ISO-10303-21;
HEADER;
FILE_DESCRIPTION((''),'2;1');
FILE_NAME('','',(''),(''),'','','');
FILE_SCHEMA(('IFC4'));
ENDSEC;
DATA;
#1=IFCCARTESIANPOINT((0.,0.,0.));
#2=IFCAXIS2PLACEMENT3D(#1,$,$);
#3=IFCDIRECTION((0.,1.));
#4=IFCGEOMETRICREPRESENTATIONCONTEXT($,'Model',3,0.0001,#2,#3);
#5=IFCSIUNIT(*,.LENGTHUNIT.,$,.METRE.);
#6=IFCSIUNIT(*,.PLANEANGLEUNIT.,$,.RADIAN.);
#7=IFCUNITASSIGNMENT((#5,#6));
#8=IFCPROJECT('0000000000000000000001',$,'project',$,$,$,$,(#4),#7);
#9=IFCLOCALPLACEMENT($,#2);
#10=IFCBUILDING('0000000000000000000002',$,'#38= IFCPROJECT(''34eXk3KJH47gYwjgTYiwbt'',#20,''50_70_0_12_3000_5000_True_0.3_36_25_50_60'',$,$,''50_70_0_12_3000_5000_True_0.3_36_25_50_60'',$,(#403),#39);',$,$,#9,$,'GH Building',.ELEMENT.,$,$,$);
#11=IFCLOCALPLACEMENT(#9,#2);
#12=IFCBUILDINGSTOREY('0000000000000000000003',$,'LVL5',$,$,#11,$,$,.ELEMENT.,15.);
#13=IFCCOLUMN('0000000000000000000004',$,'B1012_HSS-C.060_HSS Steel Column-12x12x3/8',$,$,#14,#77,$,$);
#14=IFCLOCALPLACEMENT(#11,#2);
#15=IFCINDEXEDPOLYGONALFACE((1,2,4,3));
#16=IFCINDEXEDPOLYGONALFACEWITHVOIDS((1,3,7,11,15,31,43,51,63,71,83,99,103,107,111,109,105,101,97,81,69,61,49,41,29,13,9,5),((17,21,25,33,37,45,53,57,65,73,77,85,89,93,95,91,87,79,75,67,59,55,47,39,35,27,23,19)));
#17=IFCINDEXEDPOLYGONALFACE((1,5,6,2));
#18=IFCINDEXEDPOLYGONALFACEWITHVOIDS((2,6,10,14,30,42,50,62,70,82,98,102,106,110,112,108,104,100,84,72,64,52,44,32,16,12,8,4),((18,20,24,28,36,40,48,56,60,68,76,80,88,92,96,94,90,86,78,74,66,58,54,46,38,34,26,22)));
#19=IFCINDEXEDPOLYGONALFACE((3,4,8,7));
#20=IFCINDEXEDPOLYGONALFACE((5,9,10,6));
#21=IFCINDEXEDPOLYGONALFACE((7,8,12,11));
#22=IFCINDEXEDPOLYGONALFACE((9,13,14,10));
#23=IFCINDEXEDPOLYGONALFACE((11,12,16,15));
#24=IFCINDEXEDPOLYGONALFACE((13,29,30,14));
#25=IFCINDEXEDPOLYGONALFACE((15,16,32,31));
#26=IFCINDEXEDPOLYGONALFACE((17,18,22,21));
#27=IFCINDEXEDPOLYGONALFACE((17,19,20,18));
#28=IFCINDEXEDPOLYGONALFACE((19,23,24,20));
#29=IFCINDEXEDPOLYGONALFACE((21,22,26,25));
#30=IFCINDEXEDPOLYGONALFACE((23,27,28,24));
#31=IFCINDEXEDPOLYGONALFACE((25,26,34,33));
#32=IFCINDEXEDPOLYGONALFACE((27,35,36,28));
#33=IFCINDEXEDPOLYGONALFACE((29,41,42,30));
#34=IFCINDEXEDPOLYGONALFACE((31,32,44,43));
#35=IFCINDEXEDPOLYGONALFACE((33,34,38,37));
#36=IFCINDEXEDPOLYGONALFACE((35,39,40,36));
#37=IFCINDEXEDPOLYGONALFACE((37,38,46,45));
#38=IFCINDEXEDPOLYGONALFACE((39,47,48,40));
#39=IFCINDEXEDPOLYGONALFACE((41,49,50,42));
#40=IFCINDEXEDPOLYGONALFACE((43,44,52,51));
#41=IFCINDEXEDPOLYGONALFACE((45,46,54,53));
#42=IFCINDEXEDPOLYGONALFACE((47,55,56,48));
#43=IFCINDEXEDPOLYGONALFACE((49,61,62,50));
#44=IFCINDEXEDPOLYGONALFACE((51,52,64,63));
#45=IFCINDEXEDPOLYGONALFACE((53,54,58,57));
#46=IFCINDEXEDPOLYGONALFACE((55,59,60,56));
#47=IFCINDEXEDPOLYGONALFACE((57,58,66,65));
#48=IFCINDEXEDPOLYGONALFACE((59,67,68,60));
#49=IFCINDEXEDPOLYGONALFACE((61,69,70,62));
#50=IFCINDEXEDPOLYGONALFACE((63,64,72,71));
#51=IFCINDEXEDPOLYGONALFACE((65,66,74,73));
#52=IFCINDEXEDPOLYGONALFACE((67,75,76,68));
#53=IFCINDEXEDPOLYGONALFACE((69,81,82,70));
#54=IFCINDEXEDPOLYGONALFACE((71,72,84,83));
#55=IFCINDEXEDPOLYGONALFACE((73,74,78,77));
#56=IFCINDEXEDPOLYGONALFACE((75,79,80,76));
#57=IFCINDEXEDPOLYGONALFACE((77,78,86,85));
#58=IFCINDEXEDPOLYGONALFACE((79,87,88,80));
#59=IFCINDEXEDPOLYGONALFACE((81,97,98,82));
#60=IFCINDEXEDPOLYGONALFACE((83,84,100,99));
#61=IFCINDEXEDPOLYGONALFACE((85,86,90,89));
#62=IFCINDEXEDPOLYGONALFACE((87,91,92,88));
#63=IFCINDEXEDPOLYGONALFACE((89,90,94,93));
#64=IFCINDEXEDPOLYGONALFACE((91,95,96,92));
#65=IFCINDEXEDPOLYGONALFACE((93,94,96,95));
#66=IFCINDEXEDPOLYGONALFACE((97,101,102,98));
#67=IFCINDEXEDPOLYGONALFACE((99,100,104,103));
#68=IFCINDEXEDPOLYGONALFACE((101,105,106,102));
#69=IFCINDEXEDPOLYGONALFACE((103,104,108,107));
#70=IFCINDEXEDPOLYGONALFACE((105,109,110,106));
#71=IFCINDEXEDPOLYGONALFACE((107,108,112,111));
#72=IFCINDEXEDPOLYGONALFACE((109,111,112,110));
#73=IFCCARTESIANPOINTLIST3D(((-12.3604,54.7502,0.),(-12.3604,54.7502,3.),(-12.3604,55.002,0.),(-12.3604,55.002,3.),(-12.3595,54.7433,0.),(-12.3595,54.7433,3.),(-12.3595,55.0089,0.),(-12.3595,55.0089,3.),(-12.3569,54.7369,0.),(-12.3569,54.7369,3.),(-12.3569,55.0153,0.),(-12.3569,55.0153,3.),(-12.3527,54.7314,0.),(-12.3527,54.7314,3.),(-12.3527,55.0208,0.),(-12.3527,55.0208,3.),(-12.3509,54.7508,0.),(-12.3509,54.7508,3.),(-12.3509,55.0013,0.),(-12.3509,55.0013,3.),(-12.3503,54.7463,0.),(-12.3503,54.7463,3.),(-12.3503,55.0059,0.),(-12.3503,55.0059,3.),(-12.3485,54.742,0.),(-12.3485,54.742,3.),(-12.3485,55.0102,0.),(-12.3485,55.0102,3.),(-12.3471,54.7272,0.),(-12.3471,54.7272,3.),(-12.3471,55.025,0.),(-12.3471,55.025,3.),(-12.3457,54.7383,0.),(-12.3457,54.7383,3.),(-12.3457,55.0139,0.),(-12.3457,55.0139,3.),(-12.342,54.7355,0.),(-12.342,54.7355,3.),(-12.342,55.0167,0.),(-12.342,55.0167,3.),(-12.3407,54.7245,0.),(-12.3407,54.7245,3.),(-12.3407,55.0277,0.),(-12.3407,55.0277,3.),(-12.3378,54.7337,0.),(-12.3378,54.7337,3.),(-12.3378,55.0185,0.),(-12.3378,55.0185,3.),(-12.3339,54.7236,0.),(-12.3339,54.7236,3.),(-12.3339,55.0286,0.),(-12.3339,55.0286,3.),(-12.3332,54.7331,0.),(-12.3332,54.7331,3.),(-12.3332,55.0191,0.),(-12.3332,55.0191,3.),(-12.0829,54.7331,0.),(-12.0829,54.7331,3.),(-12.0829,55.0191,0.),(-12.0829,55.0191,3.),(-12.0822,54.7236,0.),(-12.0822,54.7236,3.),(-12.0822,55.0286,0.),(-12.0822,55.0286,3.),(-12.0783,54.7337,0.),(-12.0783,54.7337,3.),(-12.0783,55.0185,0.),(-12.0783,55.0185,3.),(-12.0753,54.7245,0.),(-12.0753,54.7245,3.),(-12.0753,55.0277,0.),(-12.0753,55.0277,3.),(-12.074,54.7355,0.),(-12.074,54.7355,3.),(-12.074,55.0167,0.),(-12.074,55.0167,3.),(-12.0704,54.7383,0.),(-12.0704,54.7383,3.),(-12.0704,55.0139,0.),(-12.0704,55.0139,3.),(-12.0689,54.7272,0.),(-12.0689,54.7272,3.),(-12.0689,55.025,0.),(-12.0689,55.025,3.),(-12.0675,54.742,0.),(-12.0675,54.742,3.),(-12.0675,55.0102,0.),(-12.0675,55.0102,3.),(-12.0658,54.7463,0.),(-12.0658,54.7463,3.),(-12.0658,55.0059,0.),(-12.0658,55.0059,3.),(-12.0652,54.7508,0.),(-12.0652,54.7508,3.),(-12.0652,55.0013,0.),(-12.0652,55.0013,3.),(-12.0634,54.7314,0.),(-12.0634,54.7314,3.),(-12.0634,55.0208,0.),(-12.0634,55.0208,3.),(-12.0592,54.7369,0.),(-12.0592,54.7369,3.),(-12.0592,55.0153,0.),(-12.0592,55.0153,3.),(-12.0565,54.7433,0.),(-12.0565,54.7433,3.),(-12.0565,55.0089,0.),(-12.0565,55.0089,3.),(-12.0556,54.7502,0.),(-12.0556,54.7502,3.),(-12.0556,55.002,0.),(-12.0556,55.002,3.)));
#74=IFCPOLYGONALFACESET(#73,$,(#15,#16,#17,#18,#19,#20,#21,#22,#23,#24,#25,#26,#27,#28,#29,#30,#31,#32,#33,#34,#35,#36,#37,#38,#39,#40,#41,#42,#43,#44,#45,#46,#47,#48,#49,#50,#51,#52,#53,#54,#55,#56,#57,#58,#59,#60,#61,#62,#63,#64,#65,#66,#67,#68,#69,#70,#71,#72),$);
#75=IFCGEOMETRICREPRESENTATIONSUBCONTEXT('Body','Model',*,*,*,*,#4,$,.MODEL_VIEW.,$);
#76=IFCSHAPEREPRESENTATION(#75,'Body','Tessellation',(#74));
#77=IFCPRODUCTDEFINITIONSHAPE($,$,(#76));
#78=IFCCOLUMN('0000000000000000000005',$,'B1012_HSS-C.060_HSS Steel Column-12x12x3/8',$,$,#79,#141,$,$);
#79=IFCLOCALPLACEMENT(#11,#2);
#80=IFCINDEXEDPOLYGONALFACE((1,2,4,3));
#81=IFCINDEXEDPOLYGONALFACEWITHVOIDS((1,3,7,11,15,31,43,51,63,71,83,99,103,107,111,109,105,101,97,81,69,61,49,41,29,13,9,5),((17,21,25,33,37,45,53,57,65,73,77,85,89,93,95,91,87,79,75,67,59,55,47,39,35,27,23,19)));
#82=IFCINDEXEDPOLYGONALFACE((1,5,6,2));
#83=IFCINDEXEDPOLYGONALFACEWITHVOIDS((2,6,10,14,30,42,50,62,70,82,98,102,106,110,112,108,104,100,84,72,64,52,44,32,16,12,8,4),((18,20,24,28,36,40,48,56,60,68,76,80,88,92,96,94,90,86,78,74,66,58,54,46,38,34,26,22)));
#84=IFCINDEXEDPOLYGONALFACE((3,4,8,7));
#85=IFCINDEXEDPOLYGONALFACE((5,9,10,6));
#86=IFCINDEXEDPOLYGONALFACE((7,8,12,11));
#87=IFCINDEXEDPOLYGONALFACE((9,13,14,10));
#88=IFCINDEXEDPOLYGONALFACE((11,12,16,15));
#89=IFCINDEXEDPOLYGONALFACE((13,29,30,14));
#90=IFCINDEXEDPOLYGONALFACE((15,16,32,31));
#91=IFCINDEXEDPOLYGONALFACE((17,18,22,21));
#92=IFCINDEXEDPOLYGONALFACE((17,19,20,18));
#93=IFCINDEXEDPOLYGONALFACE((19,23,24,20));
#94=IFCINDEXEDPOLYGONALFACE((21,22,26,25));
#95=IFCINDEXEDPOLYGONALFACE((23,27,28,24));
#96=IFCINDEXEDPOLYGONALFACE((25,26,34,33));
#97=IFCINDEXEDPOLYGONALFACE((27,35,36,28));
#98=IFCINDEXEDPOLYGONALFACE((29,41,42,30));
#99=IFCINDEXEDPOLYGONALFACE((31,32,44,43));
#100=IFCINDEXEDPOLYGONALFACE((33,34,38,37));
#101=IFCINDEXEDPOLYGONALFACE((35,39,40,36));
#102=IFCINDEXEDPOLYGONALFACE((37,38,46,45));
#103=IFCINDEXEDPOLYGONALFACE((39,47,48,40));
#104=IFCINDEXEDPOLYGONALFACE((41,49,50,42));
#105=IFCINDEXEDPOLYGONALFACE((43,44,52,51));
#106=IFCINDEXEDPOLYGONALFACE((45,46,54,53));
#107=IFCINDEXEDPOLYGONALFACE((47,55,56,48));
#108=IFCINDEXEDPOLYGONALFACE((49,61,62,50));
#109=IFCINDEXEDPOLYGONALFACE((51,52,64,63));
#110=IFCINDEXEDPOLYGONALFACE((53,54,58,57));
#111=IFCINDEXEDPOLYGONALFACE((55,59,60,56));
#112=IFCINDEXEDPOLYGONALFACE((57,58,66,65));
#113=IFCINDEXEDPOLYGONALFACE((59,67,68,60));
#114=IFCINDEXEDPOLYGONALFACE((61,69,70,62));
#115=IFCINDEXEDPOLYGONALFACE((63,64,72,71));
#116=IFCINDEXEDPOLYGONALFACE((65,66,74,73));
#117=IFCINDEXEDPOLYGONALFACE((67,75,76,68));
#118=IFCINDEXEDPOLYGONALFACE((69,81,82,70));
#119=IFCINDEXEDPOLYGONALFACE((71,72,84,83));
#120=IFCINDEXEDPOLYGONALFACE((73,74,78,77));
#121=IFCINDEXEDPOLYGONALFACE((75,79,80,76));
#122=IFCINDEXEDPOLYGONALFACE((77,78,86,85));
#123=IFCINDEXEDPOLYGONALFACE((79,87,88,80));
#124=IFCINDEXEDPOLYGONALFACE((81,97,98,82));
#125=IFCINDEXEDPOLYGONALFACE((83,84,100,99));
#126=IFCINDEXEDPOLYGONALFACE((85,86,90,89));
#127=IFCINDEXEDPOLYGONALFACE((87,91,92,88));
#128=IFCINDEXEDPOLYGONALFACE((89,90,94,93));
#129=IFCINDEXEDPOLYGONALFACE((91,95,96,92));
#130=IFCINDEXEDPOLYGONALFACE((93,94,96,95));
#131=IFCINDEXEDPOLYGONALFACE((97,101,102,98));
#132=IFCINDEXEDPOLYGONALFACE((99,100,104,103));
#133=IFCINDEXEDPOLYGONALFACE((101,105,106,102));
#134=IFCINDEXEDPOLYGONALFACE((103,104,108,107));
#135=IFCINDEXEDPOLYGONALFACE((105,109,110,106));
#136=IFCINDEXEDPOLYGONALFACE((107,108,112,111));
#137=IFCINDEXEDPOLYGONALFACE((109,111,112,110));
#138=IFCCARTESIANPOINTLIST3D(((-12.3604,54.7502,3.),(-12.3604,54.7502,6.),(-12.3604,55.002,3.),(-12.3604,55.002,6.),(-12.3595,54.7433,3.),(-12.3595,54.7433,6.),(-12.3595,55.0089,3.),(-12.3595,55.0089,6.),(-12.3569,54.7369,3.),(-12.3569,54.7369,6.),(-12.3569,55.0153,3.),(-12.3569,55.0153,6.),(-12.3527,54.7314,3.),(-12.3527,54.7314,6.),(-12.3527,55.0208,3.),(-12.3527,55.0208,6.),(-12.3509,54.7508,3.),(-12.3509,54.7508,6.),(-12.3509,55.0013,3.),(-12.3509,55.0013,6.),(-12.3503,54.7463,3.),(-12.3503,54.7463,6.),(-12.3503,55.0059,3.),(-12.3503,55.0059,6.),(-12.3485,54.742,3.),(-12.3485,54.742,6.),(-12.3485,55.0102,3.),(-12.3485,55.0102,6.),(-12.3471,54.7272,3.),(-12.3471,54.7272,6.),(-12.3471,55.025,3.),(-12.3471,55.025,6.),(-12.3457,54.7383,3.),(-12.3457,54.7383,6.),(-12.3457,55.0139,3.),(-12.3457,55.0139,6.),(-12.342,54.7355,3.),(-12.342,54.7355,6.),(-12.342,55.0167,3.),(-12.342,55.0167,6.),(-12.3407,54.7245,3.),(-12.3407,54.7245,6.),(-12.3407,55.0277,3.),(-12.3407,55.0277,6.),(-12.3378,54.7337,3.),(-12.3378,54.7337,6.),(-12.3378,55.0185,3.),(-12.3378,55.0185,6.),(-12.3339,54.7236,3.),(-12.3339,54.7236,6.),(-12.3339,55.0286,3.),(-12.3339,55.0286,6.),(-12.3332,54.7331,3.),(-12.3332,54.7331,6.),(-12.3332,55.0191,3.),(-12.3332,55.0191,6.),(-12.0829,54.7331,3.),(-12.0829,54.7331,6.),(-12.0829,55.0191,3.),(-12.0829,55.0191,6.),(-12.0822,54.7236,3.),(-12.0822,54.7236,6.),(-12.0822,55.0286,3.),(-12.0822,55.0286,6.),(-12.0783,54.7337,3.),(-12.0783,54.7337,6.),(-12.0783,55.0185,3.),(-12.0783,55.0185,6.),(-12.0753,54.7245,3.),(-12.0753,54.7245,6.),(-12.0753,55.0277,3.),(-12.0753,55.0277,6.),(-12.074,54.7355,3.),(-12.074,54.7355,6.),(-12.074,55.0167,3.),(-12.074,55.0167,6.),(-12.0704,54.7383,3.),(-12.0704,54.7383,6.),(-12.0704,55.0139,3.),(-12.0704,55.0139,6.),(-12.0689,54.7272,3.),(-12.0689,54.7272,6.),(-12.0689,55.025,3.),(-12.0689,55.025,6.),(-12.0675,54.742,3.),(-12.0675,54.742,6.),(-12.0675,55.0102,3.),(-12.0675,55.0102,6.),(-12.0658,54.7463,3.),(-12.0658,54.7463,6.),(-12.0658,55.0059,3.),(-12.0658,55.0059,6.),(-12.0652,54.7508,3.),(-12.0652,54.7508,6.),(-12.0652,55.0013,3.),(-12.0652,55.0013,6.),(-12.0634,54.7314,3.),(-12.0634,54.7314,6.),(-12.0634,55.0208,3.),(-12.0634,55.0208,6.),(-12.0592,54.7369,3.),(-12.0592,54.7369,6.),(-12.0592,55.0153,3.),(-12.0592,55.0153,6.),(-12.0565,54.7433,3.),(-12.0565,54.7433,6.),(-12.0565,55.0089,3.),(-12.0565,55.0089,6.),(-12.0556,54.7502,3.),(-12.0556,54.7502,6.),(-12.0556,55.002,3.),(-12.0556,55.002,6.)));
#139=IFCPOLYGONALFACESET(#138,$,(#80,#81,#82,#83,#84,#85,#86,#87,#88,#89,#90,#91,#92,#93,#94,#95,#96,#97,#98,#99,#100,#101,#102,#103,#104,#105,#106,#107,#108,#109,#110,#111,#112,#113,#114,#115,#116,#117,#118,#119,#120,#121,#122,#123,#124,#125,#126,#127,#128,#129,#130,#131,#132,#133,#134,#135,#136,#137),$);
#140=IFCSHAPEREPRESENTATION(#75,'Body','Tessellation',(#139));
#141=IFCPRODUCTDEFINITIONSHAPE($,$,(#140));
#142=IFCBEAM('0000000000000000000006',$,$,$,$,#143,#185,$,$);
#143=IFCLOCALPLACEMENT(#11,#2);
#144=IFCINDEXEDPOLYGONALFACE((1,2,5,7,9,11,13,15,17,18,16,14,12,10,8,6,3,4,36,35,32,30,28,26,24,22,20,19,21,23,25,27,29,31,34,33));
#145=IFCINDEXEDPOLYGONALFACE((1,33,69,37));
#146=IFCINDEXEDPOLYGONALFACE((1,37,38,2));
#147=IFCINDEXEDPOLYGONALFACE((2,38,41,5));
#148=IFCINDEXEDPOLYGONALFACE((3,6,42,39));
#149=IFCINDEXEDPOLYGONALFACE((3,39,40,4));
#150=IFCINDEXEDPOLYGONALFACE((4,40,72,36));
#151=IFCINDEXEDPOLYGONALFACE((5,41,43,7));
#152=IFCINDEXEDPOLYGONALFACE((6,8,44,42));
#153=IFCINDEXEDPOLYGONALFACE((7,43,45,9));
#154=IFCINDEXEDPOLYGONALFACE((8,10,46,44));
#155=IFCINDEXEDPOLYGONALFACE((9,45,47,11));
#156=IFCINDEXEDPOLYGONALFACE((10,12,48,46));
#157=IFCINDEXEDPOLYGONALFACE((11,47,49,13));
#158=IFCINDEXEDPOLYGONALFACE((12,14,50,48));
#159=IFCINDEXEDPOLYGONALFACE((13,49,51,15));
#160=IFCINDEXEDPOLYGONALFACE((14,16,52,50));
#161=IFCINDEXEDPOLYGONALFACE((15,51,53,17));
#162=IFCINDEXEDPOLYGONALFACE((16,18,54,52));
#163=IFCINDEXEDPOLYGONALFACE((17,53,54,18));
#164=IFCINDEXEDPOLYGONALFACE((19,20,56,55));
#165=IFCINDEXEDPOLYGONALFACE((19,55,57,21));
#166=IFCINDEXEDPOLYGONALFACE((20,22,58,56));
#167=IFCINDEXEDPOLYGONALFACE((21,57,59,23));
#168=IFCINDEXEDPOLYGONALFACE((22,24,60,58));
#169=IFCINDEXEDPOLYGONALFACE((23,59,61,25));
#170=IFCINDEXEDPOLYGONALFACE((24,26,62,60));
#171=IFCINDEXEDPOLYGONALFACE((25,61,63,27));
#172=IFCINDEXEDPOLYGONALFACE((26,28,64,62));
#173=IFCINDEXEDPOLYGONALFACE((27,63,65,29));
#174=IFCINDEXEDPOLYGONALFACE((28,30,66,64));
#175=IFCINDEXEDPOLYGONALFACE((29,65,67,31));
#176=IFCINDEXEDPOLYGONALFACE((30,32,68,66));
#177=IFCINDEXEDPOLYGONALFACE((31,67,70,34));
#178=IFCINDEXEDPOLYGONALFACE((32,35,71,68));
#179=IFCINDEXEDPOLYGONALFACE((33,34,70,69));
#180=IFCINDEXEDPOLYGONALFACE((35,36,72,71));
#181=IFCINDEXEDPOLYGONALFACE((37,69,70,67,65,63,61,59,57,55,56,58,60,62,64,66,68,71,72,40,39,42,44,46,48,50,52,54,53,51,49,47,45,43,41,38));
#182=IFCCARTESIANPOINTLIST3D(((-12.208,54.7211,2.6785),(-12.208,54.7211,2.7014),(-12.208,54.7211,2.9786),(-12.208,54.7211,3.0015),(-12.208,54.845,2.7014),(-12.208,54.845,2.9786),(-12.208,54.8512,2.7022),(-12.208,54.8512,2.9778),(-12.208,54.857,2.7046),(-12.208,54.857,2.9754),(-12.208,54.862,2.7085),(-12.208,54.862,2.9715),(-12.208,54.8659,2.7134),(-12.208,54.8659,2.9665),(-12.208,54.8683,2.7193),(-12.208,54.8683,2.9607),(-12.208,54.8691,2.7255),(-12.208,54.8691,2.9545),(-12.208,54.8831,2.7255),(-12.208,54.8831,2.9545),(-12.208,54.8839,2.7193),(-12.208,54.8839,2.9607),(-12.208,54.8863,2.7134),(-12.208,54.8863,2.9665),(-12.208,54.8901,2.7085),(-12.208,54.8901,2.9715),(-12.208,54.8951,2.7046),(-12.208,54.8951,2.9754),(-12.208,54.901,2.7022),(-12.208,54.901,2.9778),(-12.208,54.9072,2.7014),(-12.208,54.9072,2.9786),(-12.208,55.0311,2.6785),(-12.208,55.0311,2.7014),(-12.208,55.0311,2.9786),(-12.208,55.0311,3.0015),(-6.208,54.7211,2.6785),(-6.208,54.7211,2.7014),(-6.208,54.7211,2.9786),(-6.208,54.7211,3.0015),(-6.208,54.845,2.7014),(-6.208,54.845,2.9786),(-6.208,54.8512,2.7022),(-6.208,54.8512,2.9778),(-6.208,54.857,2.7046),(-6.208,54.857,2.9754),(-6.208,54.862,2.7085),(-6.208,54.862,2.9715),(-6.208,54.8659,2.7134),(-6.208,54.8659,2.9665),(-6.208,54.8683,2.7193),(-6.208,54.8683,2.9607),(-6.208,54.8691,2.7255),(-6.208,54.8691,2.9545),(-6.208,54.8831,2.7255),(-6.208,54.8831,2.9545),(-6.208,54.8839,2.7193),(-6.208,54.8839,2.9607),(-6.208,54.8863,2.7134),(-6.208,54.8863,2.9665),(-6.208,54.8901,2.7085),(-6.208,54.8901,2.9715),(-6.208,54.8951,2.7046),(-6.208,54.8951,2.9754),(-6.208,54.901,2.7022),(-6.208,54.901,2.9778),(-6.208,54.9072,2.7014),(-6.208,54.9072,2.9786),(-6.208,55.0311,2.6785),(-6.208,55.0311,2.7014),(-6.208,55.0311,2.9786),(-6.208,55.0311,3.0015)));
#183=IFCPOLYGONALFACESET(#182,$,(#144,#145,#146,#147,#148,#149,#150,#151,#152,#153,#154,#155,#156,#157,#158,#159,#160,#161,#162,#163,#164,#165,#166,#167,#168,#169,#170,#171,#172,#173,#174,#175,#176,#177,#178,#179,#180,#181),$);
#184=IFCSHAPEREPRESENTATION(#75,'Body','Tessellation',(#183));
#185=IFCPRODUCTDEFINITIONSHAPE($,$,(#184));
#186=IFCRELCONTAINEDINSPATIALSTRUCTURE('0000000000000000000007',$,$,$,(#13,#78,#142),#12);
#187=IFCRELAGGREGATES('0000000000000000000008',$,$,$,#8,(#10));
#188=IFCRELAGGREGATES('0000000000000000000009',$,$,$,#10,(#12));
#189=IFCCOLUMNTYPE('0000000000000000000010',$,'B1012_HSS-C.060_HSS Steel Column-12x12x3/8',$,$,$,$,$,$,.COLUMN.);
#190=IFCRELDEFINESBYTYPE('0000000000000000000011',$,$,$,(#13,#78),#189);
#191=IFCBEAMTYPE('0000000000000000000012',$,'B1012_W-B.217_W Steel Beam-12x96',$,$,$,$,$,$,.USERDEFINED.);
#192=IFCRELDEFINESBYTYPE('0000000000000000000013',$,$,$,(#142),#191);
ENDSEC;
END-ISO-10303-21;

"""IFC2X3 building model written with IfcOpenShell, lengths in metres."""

from ifc_helpers import new_model, si_unit, direction, frame, origin, origin_2d, place, context, subcontext, project, spatial, hollow_rectangle, i_section, extrude, type_object, element, save


model = new_model("IFC2X3")

# Units and contexts
model_context = context("Model", 3, precision=0.0001, world=origin(), true_north=direction((0.0, 1.0)))
body_context = subcontext(model_context, "Body", "Model", "MODEL_VIEW")
ifc_project = project(units=[si_unit("LENGTHUNIT", "METRE"), si_unit("PLANEANGLEUNIT", "RADIAN")], contexts=[model_context])

# Building, storey
building_placement = place(None, origin())
building = spatial("IfcBuilding", under=ifc_project, at=building_placement, Name="#38= IFCPROJECT('34eXk3KJH47gYwjgTYiwbt',#20,'50_70_0_12_3000_5000_True_0.3_36_25_50_60',$,$,'50_70_0_12_3000_5000_True_0.3_36_25_50_60',$,(#403),#39);", LongName="GH Building", CompositionType="ELEMENT")
storey_placement = place(building_placement, origin())
storey = spatial("IfcBuildingStorey", under=building, at=storey_placement, Name="LVL5", CompositionType="ELEMENT", Elevation=15.0)

# Columns
column_type = type_object("IfcColumnType", Name="B1012_HSS-C.060_HSS Steel Column-12x12x3/8", PredefinedType="COLUMN")
for number, where, z_axis, x_axis, name in (
    (1, (-12.208, 54.8761, 3.0), (0.0, 0.0, -1.0), (-1.0, 0.0, 0.0), "B1012_HSS-C.060_HSS Steel Column-12x12x3/8"),
    (2, (-12.208, 54.8761, 6.0), (0.0, 0.0, -1.0), (-1.0, 0.0, 0.0), "B1012_HSS-C.060_HSS Steel Column-12x12x3/8"),
):
    element("IfcColumn", number, at=place(storey_placement, frame(where, z_axis=z_axis, x_axis=x_axis)), inside=storey, type_object=column_type, Name=name, context=body_context, shape_type="SweptSolid", body=[
        extrude(hollow_rectangle(XDim=0.3048, YDim=0.305, WallThickness=0.0095, InnerFilletRadius=0.0177, OuterFilletRadius=0.0266, at=origin_2d()), origin(), (0.0, 0.0, 1.0), 3.0),
    ])

# Beam
beam_type = type_object("IfcBeamType", Name="B1012_W-B.217_W Steel Beam-12x96", PredefinedType="USERDEFINED")
for number, where, z_axis, x_axis in (
    (3, (-12.208, 54.8761, 2.84), (1.0, 0.0, 0.0), (0.0, 1.0, 0.0)),
):
    element("IfcBeam", number, at=place(storey_placement, frame(where, z_axis=z_axis, x_axis=x_axis)), inside=storey, type_object=beam_type, context=body_context, shape_type="SweptSolid", body=[
        extrude(i_section(OverallWidth=0.31, OverallDepth=0.323, WebThickness=0.014, FlangeThickness=0.0229, FilletRadius=0.0241, at=origin_2d()), origin(), (0.0, 0.0, 1.0), 6.0),
    ])

save(model, "model.ifc")
